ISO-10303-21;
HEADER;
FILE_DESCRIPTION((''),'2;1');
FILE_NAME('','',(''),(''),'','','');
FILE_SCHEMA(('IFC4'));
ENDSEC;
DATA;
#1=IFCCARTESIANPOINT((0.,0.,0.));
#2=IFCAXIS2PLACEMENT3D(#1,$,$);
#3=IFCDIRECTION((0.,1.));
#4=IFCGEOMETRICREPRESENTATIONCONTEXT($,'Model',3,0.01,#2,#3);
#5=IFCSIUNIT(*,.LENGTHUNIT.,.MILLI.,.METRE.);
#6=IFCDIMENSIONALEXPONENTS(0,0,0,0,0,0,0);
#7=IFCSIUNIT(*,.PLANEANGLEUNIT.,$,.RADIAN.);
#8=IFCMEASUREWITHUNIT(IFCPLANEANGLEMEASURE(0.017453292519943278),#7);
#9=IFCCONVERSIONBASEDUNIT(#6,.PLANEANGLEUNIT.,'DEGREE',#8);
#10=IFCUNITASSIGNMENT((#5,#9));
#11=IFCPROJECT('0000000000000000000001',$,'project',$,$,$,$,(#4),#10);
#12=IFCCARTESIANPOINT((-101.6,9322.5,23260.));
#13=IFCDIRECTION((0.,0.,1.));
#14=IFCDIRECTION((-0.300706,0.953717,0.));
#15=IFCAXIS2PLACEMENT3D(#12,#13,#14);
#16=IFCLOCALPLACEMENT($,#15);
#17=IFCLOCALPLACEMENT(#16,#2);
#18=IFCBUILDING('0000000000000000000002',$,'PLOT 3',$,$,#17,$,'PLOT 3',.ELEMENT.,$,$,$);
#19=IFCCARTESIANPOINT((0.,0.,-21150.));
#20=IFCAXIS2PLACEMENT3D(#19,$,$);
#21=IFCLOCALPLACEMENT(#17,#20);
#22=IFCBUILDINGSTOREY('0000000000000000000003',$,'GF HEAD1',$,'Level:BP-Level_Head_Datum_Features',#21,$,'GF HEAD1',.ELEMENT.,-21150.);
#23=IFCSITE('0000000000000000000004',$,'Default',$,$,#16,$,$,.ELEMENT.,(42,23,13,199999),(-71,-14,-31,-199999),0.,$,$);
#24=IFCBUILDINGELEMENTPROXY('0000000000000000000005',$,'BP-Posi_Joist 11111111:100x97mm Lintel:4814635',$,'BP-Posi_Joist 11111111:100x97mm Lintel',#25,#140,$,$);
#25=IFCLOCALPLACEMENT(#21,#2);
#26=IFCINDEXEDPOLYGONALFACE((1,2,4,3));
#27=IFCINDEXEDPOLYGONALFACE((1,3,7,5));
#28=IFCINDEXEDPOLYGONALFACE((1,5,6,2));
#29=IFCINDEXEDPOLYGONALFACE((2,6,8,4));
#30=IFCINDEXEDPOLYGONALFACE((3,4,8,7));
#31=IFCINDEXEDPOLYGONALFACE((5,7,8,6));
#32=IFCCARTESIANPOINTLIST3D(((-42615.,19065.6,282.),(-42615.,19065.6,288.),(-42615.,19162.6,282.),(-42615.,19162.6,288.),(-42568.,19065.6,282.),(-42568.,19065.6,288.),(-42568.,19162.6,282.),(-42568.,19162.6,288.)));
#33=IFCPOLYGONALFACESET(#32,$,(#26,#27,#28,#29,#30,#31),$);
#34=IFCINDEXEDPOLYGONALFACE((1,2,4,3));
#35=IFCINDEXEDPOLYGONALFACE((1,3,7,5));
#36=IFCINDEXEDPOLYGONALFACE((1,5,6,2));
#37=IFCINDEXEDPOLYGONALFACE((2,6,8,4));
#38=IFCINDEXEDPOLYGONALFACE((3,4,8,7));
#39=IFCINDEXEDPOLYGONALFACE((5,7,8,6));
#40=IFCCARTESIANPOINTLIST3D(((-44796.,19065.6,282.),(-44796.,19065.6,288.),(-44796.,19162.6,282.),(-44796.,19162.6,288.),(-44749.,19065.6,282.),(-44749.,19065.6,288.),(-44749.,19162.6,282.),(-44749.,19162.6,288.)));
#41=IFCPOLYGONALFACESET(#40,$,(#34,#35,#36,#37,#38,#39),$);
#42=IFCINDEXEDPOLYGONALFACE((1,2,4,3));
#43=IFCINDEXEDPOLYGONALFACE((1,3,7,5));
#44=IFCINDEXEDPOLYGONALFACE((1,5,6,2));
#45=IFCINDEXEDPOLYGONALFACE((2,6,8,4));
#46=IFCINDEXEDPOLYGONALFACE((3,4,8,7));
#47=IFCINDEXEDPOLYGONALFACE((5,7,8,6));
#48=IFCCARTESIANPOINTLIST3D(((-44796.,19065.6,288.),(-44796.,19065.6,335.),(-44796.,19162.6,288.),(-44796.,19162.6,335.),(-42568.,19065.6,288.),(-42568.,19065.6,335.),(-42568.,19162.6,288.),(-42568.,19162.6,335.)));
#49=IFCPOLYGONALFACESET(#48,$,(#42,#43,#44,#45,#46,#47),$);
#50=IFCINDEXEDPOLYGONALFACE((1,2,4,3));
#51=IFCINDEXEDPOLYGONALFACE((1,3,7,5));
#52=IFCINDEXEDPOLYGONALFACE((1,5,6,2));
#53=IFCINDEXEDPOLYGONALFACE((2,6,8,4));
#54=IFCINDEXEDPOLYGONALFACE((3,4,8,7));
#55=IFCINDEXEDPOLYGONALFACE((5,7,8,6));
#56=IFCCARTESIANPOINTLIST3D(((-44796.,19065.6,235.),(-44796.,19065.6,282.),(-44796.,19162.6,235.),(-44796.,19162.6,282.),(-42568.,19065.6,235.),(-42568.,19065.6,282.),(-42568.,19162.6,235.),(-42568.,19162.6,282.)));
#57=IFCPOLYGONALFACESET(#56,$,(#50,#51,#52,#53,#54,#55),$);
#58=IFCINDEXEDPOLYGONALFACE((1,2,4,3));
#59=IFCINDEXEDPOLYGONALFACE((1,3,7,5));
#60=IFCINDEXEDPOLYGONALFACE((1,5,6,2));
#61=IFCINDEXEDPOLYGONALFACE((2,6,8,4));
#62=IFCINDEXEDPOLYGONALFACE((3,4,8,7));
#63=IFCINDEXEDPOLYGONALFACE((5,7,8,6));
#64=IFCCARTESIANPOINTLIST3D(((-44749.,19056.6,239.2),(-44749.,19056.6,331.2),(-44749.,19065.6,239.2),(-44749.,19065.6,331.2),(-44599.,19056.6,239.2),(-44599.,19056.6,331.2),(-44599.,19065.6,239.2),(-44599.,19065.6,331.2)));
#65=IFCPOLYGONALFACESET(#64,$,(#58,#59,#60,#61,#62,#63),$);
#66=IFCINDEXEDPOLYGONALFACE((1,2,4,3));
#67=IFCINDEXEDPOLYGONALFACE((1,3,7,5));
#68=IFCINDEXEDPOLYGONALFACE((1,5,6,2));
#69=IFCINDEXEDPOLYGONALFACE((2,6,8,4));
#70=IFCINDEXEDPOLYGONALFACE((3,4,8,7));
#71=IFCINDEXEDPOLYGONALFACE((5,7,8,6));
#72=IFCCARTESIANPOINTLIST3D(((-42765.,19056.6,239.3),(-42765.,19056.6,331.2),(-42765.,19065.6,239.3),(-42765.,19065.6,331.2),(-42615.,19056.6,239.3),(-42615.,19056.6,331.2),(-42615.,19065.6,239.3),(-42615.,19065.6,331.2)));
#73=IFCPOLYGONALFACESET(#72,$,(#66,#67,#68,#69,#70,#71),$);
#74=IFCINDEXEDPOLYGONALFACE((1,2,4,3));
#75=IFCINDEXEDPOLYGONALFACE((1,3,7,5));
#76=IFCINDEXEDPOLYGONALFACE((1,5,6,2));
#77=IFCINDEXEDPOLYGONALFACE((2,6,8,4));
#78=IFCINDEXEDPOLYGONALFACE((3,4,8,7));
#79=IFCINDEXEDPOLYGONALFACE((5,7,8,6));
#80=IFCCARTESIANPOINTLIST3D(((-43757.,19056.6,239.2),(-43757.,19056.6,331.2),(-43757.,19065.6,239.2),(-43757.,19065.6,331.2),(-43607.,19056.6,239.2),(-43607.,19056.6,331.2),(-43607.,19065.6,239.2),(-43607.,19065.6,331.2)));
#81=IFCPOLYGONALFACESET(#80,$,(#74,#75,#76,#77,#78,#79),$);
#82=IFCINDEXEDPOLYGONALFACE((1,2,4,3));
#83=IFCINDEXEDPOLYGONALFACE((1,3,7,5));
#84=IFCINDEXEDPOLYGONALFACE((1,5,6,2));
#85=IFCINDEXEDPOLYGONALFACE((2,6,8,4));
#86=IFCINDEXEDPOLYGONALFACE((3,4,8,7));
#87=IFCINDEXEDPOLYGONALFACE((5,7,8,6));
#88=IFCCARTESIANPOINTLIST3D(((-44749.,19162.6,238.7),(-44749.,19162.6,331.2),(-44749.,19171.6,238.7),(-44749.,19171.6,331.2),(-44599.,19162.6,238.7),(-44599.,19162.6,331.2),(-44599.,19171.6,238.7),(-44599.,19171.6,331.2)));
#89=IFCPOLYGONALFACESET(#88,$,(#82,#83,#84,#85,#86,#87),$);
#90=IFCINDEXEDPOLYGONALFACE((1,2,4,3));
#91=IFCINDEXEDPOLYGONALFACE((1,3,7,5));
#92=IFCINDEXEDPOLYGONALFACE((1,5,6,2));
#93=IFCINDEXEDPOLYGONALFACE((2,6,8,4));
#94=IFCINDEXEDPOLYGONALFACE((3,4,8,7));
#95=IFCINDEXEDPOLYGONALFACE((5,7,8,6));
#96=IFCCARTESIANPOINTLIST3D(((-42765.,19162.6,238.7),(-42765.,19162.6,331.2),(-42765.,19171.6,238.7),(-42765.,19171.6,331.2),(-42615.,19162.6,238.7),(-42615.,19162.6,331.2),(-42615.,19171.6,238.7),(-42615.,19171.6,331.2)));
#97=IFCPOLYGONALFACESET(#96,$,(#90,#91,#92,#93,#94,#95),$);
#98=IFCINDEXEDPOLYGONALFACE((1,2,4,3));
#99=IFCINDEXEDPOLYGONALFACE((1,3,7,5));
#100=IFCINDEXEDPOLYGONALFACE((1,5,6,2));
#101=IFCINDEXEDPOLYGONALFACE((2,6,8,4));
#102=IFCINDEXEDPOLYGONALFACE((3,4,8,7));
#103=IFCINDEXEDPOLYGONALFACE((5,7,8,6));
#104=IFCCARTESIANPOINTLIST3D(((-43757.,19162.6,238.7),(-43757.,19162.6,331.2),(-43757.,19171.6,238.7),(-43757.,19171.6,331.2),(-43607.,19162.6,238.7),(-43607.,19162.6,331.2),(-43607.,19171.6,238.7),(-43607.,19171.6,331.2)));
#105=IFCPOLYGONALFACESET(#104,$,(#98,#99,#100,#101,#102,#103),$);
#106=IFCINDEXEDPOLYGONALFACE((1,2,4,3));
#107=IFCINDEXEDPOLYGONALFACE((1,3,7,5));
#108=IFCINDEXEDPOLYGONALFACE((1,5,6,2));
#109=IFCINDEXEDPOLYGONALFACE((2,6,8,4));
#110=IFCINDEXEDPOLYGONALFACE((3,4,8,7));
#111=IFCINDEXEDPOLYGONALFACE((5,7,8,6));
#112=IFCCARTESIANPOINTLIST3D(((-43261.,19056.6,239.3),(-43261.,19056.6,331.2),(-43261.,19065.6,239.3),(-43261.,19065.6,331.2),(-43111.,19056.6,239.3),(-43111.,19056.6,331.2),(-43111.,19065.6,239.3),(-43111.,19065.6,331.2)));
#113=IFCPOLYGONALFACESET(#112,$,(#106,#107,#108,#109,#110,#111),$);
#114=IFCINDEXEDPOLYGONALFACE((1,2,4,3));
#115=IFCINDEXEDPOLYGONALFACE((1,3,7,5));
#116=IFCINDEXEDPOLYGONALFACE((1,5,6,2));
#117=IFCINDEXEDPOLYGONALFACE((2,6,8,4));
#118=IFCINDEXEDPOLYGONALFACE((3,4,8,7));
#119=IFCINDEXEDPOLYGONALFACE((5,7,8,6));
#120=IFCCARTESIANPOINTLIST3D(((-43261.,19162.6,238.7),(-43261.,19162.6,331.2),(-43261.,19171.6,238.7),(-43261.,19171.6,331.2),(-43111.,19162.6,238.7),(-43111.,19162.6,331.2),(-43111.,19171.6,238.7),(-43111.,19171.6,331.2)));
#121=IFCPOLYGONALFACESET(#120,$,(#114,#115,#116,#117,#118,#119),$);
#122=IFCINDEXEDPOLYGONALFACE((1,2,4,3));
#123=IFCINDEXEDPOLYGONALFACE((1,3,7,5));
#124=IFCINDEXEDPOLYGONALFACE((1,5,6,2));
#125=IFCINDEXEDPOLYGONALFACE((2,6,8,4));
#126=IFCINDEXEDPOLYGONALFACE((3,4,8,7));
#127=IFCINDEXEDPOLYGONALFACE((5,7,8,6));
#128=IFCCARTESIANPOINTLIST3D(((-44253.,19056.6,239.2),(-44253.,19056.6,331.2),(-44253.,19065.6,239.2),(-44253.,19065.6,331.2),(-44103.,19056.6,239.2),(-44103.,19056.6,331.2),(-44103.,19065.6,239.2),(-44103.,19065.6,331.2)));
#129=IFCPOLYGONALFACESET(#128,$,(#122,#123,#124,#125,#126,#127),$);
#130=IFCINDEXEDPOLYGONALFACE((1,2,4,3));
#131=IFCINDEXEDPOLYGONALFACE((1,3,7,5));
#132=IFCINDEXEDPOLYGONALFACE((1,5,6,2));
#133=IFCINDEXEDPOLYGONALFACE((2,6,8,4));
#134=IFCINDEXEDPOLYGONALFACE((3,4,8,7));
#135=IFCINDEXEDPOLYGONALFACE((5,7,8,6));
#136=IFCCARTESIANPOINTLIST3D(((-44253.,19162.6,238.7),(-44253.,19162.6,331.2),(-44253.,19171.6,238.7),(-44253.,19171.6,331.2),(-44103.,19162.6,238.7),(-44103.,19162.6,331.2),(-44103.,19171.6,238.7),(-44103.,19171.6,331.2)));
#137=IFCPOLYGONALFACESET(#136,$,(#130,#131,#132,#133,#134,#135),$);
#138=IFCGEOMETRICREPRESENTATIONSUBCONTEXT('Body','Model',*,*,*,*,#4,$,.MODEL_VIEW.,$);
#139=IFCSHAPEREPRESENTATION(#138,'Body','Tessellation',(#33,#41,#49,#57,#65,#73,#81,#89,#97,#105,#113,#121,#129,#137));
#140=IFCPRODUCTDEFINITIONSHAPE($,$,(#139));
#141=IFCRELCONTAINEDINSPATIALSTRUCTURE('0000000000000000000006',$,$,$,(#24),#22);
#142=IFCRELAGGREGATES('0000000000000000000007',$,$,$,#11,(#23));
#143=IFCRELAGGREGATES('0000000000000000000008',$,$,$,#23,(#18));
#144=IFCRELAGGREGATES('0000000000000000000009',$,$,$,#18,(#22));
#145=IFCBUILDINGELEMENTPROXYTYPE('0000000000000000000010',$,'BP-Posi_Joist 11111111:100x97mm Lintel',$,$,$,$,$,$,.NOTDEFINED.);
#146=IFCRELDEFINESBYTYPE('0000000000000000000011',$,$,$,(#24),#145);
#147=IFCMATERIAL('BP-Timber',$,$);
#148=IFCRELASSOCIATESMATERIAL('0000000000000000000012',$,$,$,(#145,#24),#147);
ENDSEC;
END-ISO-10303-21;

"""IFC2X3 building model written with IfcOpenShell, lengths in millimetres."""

from ifc_helpers import new_model, entity, si_unit, converted_unit, direction, frame, frame_2d, origin, origin_2d_with_axis, place, context, subcontext, project, spatial, rectangle, extrude, source, transform, mapped, material, type_object, type_shapes, element, save


model = new_model("IFC2X3")

# Units and contexts
model_context = context("Model", 3, precision=0.01, world=origin(), true_north=direction((0.0, 1.0)))
body_context = subcontext(model_context, "Body", "Model", "MODEL_VIEW")
ifc_project = project(units=[si_unit("LENGTHUNIT", "METRE", prefix="MILLI"), converted_unit("PLANEANGLEUNIT", "DEGREE", entity("IfcPlaneAngleMeasure", 0.017453292519943278), si_unit("PLANEANGLEUNIT", "RADIAN"), dimensions=[0, 0, 0, 0, 0, 0, 0])], contexts=[model_context])

# Site, building, storey
site_placement = place(None, frame((-101.6, 9322.5, 23260.0), z_axis=(0.0, 0.0, 1.0), x_axis=(-0.300706, 0.953717, 0.0)))
site = spatial("IfcSite", under=ifc_project, at=site_placement, Name="Default", CompositionType="ELEMENT", RefLatitude=(42, 23, 13, 199999), RefLongitude=(-71, -14, -31, -199999), RefElevation=0.0)
building_placement = place(site_placement, origin())
building = spatial("IfcBuilding", under=site, at=building_placement, Name="PLOT 3", LongName="PLOT 3", CompositionType="ELEMENT")
storey_placement = place(building_placement, frame((0.0, 0.0, -21150.0)))
storey = spatial("IfcBuildingStorey", under=building, at=storey_placement, Name="GF HEAD1", ObjectType="Level:BP-Level_Head_Datum_Features", LongName="GF HEAD1", CompositionType="ELEMENT", Elevation=-21150.0)

# Shared definitions
ifc_material_1 = material(Name="BP-Timber")

# Building element proxy
building_element_proxy_type_1 = type_object("IfcBuildingElementProxyType", Name="BP-Posi_Joist 11111111:100x97mm Lintel", PredefinedType="NOTDEFINED", material=ifc_material_1)
shared_shape_1 = source(origin(), body_context, "Body", "SweptSolid", [
    extrude(rectangle(XDim=47.0, YDim=97.0, at=origin_2d_with_axis()), frame((320.4, 0.0, -53.0), z_axis=(0.0, 0.0, 1.0), x_axis=(-1.0, 0.0, 0.0)), (0.0, 0.0, 1.0), 6.0),
    extrude(rectangle(XDim=47.0, YDim=97.0, at=frame_2d((0.0, 0.0), x_axis=(1.0, 0.0))), frame((2501.4, 0.0, -53.0), z_axis=(0.0, 0.0, 1.0), x_axis=(-1.0, 0.0, 0.0)), (0.0, 0.0, 1.0), 6.0),
    extrude(rectangle(XDim=97.0, YDim=2228.0, at=frame_2d((0.0, 0.0), x_axis=(1.0, 0.0))), frame((1410.9, 0.0, -47.0), z_axis=(0.0, 0.0, 1.0), x_axis=(0.0, -1.0, 0.0)), (0.0, 0.0, 1.0), 47.0),
    extrude(rectangle(XDim=97.0, YDim=2228.0, at=origin_2d_with_axis()), frame((1410.9, 0.0, -100.0), z_axis=(0.0, 0.0, 1.0), x_axis=(0.0, -1.0, 0.0)), (0.0, 0.0, 1.0), 47.0),
    extrude(rectangle(XDim=9.0, YDim=150.0, at=frame_2d((0.0, 0.0), x_axis=(1.0, 0.0))), frame((2402.9, 53.0, -95.8), z_axis=(0.0, 0.0, 1.0), x_axis=(0.0, -1.0, 0.0)), (0.0, 0.0, 1.0), 92.0),
    extrude(rectangle(XDim=9.0, YDim=150.0, at=frame_2d((0.0, 0.0), x_axis=(1.0, 0.0))), frame((418.9, 53.0, -95.7), z_axis=(0.0, 0.0, 1.0), x_axis=(0.0, 1.0, 0.0)), (0.0, 0.0, 1.0), 92.0),
    extrude(rectangle(XDim=9.0, YDim=150.0, at=frame_2d((0.0, 0.0), x_axis=(1.0, 0.0))), frame((1410.9, 53.0, -95.8), z_axis=(0.0, 0.0, 1.0), x_axis=(0.0, -1.0, 0.0)), (0.0, 0.0, 1.0), 92.0),
    extrude(rectangle(XDim=9.0, YDim=150.0, at=frame_2d((0.0, 0.0), x_axis=(1.0, 0.0))), frame((2402.9, -53.0, -96.3), z_axis=(0.0, 0.0, 1.0), x_axis=(0.0, -1.0, 0.0)), (0.0, 0.0, 1.0), 92.5),
    extrude(rectangle(XDim=9.0, YDim=150.0, at=frame_2d((0.0, 0.0), x_axis=(1.0, 0.0))), frame((418.9, -53.0, -96.3), z_axis=(0.0, 0.0, 1.0), x_axis=(0.0, 1.0, 0.0)), (0.0, 0.0, 1.0), 92.5),
    extrude(rectangle(XDim=9.0, YDim=150.0, at=origin_2d_with_axis()), frame((1410.9, -53.0, -96.3), z_axis=(0.0, 0.0, 1.0), x_axis=(0.0, -1.0, 0.0)), (0.0, 0.0, 1.0), 92.5),
    extrude(rectangle(XDim=9.0, YDim=150.0, at=frame_2d((0.0, 0.0), x_axis=(1.0, 0.0))), frame((914.9, 53.0, -95.7), z_axis=(0.0, 0.0, 1.0), x_axis=(0.0, 1.0, 0.0)), (0.0, 0.0, 1.0), 92.0),
    extrude(rectangle(XDim=9.0, YDim=150.0, at=frame_2d((0.0, 0.0), x_axis=(1.0, 0.0))), frame((914.9, -53.0, -96.3), z_axis=(0.0, 0.0, 1.0), x_axis=(0.0, 1.0, 0.0)), (0.0, 0.0, 1.0), 92.5),
    extrude(rectangle(XDim=9.0, YDim=150.0, at=origin_2d_with_axis()), frame((1906.9, 53.0, -95.8), z_axis=(0.0, 0.0, 1.0), x_axis=(0.0, -1.0, 0.0)), (0.0, 0.0, 1.0), 92.0),
    extrude(rectangle(XDim=9.0, YDim=150.0, at=origin_2d_with_axis()), frame((1906.9, -53.0, -96.3), z_axis=(0.0, 0.0, 1.0), x_axis=(0.0, -1.0, 0.0)), (0.0, 0.0, 1.0), 92.5),
])
type_shapes(building_element_proxy_type_1, [shared_shape_1])
for number, where, z_axis, x_axis, name in (
    (1, (-42271.1, 19114.1, 335.0), (0.0, 0.0, 1.0), (-1.0, 0.0, 0.0), "BP-Posi_Joist 11111111:100x97mm Lintel:4814635"),
):
    element("IfcBuildingElementProxy", number, at=place(storey_placement, frame(where, z_axis=z_axis, x_axis=x_axis)), inside=storey, type_object=building_element_proxy_type_1, material=ifc_material_1, Name=name, ObjectType="BP-Posi_Joist 11111111:100x97mm Lintel", context=body_context, shape_type="MappedRepresentation", body=[
        mapped(shared_shape_1, transform((0.0, 0.0, 0.0), scale=1.0)),
    ])

save(model, "model.ifc")
